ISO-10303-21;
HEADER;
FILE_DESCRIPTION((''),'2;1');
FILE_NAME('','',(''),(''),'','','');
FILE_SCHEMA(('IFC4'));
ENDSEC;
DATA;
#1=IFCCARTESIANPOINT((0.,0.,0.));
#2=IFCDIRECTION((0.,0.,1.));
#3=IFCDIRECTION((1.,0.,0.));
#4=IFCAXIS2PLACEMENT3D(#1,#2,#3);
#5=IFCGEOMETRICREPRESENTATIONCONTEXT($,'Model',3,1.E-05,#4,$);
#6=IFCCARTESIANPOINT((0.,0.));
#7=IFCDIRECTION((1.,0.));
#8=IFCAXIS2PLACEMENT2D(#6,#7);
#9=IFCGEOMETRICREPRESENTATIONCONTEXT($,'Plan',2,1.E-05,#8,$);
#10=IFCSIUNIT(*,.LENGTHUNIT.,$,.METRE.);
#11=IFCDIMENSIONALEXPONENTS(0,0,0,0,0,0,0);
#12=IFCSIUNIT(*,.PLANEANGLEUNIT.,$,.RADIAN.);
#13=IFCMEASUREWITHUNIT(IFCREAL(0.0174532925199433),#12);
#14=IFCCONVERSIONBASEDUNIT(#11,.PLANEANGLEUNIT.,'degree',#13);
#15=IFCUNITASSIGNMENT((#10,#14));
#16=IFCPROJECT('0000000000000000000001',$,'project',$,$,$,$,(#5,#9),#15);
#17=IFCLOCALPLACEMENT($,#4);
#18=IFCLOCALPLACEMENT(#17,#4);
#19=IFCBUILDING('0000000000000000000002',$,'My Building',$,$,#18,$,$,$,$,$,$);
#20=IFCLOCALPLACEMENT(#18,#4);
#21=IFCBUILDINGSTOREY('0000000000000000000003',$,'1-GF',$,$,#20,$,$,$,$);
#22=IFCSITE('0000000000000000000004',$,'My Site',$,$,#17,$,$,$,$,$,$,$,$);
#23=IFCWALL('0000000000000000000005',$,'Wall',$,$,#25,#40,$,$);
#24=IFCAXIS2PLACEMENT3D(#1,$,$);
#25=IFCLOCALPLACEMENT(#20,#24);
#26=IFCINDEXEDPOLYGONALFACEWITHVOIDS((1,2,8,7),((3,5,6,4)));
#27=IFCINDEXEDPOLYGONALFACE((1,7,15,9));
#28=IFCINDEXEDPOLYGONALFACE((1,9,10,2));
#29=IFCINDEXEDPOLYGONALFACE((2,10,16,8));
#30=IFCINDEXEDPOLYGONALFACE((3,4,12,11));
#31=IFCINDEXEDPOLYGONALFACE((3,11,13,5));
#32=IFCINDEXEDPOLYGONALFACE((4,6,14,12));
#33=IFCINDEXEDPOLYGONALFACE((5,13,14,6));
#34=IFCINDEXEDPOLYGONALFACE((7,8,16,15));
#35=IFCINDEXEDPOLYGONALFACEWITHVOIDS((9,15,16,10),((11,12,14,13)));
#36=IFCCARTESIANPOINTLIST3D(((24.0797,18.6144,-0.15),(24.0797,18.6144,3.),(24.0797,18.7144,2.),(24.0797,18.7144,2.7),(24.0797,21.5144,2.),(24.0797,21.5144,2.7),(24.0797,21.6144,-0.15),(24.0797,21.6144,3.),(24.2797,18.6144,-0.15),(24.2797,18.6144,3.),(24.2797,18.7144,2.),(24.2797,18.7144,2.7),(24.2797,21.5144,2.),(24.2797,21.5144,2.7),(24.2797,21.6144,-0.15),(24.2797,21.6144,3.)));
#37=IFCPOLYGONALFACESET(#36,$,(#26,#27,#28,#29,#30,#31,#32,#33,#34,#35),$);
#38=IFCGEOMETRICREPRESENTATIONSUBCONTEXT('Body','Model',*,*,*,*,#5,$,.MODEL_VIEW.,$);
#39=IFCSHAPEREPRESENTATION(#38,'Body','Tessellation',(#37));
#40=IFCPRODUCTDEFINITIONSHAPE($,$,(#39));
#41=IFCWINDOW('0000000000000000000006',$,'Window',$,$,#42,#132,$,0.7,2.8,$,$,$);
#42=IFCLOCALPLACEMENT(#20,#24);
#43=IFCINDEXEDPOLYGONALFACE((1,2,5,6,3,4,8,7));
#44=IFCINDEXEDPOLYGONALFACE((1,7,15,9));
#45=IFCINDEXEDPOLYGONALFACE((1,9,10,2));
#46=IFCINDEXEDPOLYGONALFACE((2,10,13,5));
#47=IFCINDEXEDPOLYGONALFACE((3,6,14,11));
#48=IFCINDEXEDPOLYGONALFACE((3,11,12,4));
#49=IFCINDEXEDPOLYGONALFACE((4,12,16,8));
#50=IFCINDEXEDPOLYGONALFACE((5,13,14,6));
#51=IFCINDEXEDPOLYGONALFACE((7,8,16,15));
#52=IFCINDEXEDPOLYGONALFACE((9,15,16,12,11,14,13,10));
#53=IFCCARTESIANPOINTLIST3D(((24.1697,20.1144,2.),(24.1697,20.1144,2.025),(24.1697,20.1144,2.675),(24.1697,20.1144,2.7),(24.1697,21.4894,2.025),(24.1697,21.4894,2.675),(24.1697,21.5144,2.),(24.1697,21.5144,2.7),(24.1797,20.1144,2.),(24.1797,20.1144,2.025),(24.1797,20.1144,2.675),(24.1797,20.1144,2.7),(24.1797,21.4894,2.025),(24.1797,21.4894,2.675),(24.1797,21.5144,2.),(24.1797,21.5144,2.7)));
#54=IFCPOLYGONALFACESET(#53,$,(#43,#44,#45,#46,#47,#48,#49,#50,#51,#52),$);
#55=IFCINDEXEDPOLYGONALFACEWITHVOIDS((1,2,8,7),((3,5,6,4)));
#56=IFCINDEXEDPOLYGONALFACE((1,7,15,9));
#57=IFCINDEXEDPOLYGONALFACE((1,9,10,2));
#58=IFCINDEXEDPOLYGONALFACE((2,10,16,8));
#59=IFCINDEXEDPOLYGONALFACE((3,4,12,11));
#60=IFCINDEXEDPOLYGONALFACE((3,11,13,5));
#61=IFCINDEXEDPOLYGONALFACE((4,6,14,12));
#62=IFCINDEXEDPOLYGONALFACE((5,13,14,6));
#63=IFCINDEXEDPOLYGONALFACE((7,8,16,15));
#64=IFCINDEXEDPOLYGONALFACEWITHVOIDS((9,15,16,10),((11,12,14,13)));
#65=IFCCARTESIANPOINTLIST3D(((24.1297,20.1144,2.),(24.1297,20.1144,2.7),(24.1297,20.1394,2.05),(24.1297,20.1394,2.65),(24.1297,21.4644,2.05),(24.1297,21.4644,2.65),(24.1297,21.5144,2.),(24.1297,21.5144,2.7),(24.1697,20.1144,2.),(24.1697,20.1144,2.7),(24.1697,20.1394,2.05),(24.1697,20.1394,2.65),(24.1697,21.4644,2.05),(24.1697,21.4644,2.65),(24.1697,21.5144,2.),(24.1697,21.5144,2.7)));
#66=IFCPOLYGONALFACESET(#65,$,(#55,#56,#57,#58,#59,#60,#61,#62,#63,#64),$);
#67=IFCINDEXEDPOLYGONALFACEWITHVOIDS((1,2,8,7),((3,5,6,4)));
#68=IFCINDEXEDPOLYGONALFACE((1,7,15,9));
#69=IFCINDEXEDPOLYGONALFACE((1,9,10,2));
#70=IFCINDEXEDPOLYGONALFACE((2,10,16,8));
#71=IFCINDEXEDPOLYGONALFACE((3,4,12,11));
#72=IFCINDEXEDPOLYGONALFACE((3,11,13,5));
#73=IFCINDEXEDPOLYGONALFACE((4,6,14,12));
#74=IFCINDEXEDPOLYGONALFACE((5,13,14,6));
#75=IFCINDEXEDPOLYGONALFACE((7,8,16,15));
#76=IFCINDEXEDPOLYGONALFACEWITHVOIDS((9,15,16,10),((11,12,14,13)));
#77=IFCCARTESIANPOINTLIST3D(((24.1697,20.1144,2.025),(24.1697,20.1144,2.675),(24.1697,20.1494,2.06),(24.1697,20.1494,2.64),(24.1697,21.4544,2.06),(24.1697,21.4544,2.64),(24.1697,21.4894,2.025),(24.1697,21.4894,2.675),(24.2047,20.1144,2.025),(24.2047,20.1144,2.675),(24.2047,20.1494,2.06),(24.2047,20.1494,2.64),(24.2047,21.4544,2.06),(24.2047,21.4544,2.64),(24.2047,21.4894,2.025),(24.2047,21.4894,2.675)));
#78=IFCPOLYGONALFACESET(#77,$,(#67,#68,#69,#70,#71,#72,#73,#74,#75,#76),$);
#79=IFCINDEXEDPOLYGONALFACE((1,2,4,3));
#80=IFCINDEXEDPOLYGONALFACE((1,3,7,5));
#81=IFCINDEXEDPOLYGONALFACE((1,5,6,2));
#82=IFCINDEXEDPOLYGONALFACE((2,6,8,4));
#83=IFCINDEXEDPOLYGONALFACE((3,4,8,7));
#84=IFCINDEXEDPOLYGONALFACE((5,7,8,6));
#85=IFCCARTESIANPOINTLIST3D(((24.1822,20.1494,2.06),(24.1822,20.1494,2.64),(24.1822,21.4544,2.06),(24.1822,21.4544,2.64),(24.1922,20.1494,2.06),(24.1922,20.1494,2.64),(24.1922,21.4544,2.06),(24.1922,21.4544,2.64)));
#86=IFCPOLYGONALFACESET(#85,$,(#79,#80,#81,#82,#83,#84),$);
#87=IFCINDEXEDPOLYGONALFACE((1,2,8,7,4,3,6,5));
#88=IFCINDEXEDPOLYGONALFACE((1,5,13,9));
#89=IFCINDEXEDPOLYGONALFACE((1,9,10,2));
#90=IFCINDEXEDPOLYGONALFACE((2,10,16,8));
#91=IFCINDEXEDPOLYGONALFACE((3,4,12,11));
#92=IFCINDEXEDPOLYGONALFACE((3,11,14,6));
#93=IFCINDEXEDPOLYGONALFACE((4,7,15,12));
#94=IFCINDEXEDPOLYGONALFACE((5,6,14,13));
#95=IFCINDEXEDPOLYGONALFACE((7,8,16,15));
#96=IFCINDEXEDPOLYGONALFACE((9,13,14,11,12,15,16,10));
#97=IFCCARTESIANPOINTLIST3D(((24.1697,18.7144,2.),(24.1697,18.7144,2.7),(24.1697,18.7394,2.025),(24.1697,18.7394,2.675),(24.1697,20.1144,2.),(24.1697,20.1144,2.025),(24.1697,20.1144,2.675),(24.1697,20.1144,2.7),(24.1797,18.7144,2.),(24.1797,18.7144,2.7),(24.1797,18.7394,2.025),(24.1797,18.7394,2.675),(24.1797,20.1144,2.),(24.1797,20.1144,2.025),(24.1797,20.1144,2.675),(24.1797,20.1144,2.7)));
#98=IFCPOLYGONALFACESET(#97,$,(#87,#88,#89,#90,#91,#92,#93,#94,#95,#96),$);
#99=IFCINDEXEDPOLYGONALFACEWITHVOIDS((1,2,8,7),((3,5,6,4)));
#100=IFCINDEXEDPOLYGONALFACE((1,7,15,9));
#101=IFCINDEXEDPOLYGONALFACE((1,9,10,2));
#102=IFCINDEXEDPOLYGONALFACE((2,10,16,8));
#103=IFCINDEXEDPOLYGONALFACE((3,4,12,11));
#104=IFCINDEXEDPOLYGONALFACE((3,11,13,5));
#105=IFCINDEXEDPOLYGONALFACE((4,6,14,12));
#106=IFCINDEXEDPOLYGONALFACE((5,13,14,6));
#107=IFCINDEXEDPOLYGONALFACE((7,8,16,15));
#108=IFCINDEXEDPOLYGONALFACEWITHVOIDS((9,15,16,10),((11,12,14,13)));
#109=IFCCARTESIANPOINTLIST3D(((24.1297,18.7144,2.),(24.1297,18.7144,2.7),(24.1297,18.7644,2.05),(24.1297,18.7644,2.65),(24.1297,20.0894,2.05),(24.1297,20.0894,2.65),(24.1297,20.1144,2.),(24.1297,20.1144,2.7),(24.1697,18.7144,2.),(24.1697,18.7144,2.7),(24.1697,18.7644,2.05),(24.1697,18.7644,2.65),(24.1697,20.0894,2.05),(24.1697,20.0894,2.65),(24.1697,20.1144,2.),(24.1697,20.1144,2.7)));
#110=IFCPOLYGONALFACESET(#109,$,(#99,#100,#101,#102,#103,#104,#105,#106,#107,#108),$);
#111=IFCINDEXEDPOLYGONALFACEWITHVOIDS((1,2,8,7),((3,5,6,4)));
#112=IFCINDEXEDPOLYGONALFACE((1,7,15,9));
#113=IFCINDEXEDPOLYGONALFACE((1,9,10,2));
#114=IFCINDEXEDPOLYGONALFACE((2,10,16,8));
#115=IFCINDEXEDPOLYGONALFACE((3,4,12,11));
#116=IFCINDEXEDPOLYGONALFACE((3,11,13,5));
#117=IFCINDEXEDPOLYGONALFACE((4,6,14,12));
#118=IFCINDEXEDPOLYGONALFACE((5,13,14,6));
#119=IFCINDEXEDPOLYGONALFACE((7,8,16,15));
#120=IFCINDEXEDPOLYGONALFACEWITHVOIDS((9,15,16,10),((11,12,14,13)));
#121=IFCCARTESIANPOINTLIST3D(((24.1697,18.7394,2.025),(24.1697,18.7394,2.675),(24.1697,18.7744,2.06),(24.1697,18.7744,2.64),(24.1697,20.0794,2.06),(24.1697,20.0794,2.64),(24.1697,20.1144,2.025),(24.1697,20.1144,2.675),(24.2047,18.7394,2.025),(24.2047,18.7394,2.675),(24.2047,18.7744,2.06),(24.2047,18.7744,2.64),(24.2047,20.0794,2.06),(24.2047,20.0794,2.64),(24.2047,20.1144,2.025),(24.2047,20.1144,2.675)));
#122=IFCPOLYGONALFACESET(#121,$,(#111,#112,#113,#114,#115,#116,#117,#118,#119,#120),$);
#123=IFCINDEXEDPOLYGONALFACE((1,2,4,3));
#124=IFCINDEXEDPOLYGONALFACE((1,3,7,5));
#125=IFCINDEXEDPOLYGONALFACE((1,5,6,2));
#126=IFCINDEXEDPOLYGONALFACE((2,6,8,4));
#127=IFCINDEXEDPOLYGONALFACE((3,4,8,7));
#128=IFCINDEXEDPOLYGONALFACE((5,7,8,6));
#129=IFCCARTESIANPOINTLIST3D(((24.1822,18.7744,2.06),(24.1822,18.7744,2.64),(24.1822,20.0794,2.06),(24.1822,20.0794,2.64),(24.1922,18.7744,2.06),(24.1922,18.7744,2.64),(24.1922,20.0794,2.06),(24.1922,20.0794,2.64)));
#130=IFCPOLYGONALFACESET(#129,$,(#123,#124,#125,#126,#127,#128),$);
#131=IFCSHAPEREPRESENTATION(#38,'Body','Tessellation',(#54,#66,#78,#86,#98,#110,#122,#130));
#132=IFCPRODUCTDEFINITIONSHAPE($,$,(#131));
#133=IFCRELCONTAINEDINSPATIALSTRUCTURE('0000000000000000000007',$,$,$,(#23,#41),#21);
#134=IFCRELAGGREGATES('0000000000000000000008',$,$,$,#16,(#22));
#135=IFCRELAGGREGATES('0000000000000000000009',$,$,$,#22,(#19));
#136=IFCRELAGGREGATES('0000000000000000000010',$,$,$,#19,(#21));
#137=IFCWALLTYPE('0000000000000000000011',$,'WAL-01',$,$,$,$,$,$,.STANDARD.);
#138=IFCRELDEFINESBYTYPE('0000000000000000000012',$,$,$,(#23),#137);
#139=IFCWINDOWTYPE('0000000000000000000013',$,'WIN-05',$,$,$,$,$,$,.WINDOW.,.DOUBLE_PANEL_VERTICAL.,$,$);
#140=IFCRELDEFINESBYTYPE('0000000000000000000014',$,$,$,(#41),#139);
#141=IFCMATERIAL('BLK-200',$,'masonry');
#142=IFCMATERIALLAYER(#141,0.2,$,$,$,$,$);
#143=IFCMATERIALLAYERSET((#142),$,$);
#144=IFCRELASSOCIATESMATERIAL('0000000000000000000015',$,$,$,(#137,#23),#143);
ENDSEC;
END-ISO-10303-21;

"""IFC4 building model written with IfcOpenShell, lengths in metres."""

from ifc_helpers import new_model, entity, si_unit, converted_unit, frame, origin_with_axes, origin_2d_with_axis, place, context, subcontext, project, spatial, line, indexed_curve, outline, extrude, shape, source, transform, mapped, material, layer, layer_set, layer_usage, type_object, type_shapes, element, fill, save


model = new_model("IFC4")

# Units and contexts
model_context = context("Model", 3, precision=1e-05, world=origin_with_axes())
plan_context = context("Plan", 2, precision=1e-05, world=origin_2d_with_axis())
body_context_1 = subcontext(model_context, "Body", "Model", "MODEL_VIEW")
body_context_2 = subcontext(plan_context, "Body", "Plan", "PLAN_VIEW")
ifc_project = project(units=[si_unit("LENGTHUNIT", "METRE"), converted_unit("PLANEANGLEUNIT", "degree", entity("IfcReal", 0.0174532925199433), si_unit("PLANEANGLEUNIT", "RADIAN"), dimensions=[0, 0, 0, 0, 0, 0, 0])], contexts=[model_context, plan_context])

# Site, building, storey
site_placement = place(None, origin_with_axes())
site = spatial("IfcSite", under=ifc_project, at=site_placement, Name="My Site")
building_placement = place(site_placement, origin_with_axes())
building = spatial("IfcBuilding", under=site, at=building_placement, Name="My Building")
storey_placement = place(building_placement, origin_with_axes())
storey = spatial("IfcBuildingStorey", under=building, at=storey_placement, Name="1-GF")

# Wall, opening, window
ifc_material_1 = material(Name="BLK-200", Category="masonry")
ifc_layer_1 = layer(ifc_material_1, 0.2)
ifc_layer_set_1 = layer_set([ifc_layer_1])
ifc_layer_usage_1 = layer_usage(ifc_layer_set_1, "AXIS2", "POSITIVE", 0.0)
wall_type_1 = type_object("IfcWallType", Name="WAL-01", PredefinedType="STANDARD", material=ifc_layer_set_1)
wall_1_placement = place(storey_placement, frame((24.0797, 21.6144, -0.15), z_axis=(0.0, 0.0, 1.0), x_axis=(-0.000001, -1.0, 0.0)))
wall_1 = element("IfcWall", 1, at=wall_1_placement, inside=storey, type_object=wall_type_1, material=ifc_layer_usage_1, Name="Wall", context=body_context_1, shape_type="SweptSolid", body=[
    extrude(outline(indexed_curve([(0.0, 0.0), (0.0, 0.2), (3.0, 0.2), (3.0, 0.0), (0.0, 0.0)], self_intersect=False)), origin_with_axes(), (0.0, 0.0, 1.0), 3.15),
])
shared_shape_1 = source(origin_with_axes(), body_context_1, "Body", "SweptSolid", [
    extrude(outline(indexed_curve([(0.0, 0.0), (2.8, 0.0), (2.8, 0.7), (0.0, 0.7)], segments=[line(1, 2, 3, 4, 1)])), frame((0.0, -0.6, 0.0), z_axis=(0.0, -1.0, 0.0), x_axis=(1.0, 0.0, 0.0)), (0.0, 0.0, -1.0), 1.2),
])
opening_1_placement = place(wall_1_placement, frame((0.1, 0.0, 2.15), z_axis=(0.0, 0.0, 1.0), x_axis=(1.0, 0.0, 0.0)))
opening_1 = element("IfcOpeningElement", 2, at=opening_1_placement, cuts=wall_1, PredefinedType="OPENING", context=body_context_1, shape_type="MappedRepresentation", body=[
    mapped(shared_shape_1, transform((0.0, 0.0, 0.0), x_axis=(1.0, 0.0, 0.0), y_axis=(0.0, 1.0, 0.0), z_axis=(0.0, 0.0, 1.0), scale=1.0)),
])
window_type_1 = type_object("IfcWindowType", Name="WIN-05", PartitioningType="DOUBLE_PANEL_VERTICAL", PredefinedType="WINDOW")
shared_shape_2 = source(origin_with_axes(), body_context_1, "Body", "SweptSolid", [
    extrude(outline(indexed_curve([(1.4, 0.0), (0.0, 0.0), (0.0, 0.7), (1.4, 0.7), (1.4, 0.675), (0.025, 0.675), (0.025, 0.025), (1.4, 0.025)], segments=[line(1, 2, 3, 4, 5, 6, 7, 8, 1)])), frame((0.0, 0.09, 0.0), z_axis=(0.0, -1.0, 0.0), x_axis=(1.0, 0.0, 0.0)), (0.0, 0.0, -1.0), 0.01),
    extrude(outline(indexed_curve([(0.0, 0.0), (1.4, 0.0), (1.4, 0.7), (0.0, 0.7)], segments=[line(1, 2, 3, 4, 1)]), holes=[indexed_curve([(0.05, 0.05), (1.375, 0.05), (1.375, 0.65), (0.05, 0.65)], segments=[line(1, 2, 3, 4, 1)])]), frame((0.0, 0.05, 0.0), z_axis=(0.0, -1.0, 0.0), x_axis=(1.0, 0.0, 0.0)), (0.0, 0.0, -1.0), 0.04),
    extrude(outline(indexed_curve([(0.0, 0.0), (1.375, 0.0), (1.375, 0.65), (0.0, 0.65)], segments=[line(1, 2, 3, 4, 1)]), holes=[indexed_curve([(0.035, 0.035), (1.34, 0.035), (1.34, 0.615), (0.035, 0.615)], segments=[line(1, 2, 3, 4, 1)])]), frame((0.025, 0.09, 0.025), z_axis=(0.0, -1.0, 0.0), x_axis=(1.0, 0.0, 0.0)), (0.0, 0.0, -1.0), 0.035),
    extrude(outline(indexed_curve([(0.035, 0.035), (1.34, 0.035), (1.34, 0.615), (0.035, 0.615)], segments=[line(1, 2, 3, 4, 1)])), frame((0.025, 0.1025, 0.025), z_axis=(0.0, -1.0, 0.0), x_axis=(1.0, 0.0, 0.0)), (0.0, 0.0, -1.0), 0.01),
    extrude(outline(indexed_curve([(0.0, 0.7), (1.4, 0.7), (1.4, 0.0), (0.0, 0.0), (0.0, 0.025), (1.375, 0.025), (1.375, 0.675), (0.0, 0.675)], segments=[line(1, 2, 3, 4, 5, 6, 7, 8, 1)])), frame((1.4, 0.09, 0.0), z_axis=(0.0, -1.0, 0.0), x_axis=(1.0, 0.0, 0.0)), (0.0, 0.0, -1.0), 0.01),
    extrude(outline(indexed_curve([(0.0, 0.0), (1.4, 0.0), (1.4, 0.7), (0.0, 0.7)], segments=[line(1, 2, 3, 4, 1)]), holes=[indexed_curve([(0.025, 0.05), (1.35, 0.05), (1.35, 0.65), (0.025, 0.65)], segments=[line(1, 2, 3, 4, 1)])]), frame((1.4, 0.05, 0.0), z_axis=(0.0, -1.0, 0.0), x_axis=(1.0, 0.0, 0.0)), (0.0, 0.0, -1.0), 0.04),
    extrude(outline(indexed_curve([(0.0, 0.0), (1.375, 0.0), (1.375, 0.65), (0.0, 0.65)], segments=[line(1, 2, 3, 4, 1)]), holes=[indexed_curve([(0.035, 0.035), (1.34, 0.035), (1.34, 0.615), (0.035, 0.615)], segments=[line(1, 2, 3, 4, 1)])]), frame((1.4, 0.09, 0.025), z_axis=(0.0, -1.0, 0.0), x_axis=(1.0, 0.0, 0.0)), (0.0, 0.0, -1.0), 0.035),
    extrude(outline(indexed_curve([(0.035, 0.035), (1.34, 0.035), (1.34, 0.615), (0.035, 0.615)], segments=[line(1, 2, 3, 4, 1)])), frame((1.4, 0.1025, 0.025), z_axis=(0.0, -1.0, 0.0), x_axis=(1.0, 0.0, 0.0)), (0.0, 0.0, -1.0), 0.01),
])
shared_shape_3 = source(origin_with_axes(), body_context_2, "Body", "Curve2D", [
    entity("IfcIndexedPolyCurve", entity("IfcCartesianPointList2D", [[0.05, 0.05], [1.375, 0.05]])),
    entity("IfcIndexedPolyCurve", entity("IfcCartesianPointList2D", [[0.0, 0.1], [0.025, 0.1], [0.025, 0.09], [0.05, 0.09], [0.05, 0.05], [0.0, 0.05]]), [entity("IfcLineIndex", [1, 2, 3, 4, 5, 6, 1])]),
    entity("IfcIndexedPolyCurve", entity("IfcCartesianPointList2D", [[1.4, 0.1], [1.4, 0.1], [1.4, 0.09], [1.375, 0.09], [1.375, 0.05], [1.4, 0.05]])),
    entity("IfcIndexedPolyCurve", entity("IfcCartesianPointList2D", [[0.025, 0.09], [0.06, 0.09], [0.06, 0.125], [0.025, 0.125]]), [entity("IfcLineIndex", [1, 2, 3, 4, 1])]),
    entity("IfcIndexedPolyCurve", entity("IfcCartesianPointList2D", [[1.4, 0.09], [1.365, 0.09], [1.365, 0.125], [1.4, 0.125]]), [entity("IfcLineIndex", [1, 2, 3, 4, 1])]),
    entity("IfcIndexedPolyCurve", entity("IfcCartesianPointList2D", [[0.06, 0.09], [1.365, 0.09]])),
    entity("IfcIndexedPolyCurve", entity("IfcCartesianPointList2D", [[0.06, 0.125], [1.365, 0.125]])),
    entity("IfcIndexedPolyCurve", entity("IfcCartesianPointList2D", [[0.06, 0.1075], [1.365, 0.1075]])),
    entity("IfcIndexedPolyCurve", entity("IfcCartesianPointList2D", [[1.425, 0.05], [2.75, 0.05]])),
    entity("IfcIndexedPolyCurve", entity("IfcCartesianPointList2D", [[1.4, 0.1], [1.4, 0.1], [1.4, 0.09], [1.425, 0.09], [1.425, 0.05], [1.4, 0.05]])),
    entity("IfcIndexedPolyCurve", entity("IfcCartesianPointList2D", [[2.8, 0.1], [2.775, 0.1], [2.775, 0.09], [2.75, 0.09], [2.75, 0.05], [2.8, 0.05]]), [entity("IfcLineIndex", [1, 2, 3, 4, 5, 6, 1])]),
    entity("IfcIndexedPolyCurve", entity("IfcCartesianPointList2D", [[1.4, 0.09], [1.435, 0.09], [1.435, 0.125], [1.4, 0.125]]), [entity("IfcLineIndex", [1, 2, 3, 4, 1])]),
    entity("IfcIndexedPolyCurve", entity("IfcCartesianPointList2D", [[2.775, 0.09], [2.74, 0.09], [2.74, 0.125], [2.775, 0.125]]), [entity("IfcLineIndex", [1, 2, 3, 4, 1])]),
    entity("IfcIndexedPolyCurve", entity("IfcCartesianPointList2D", [[1.435, 0.09], [2.74, 0.09]])),
    entity("IfcIndexedPolyCurve", entity("IfcCartesianPointList2D", [[1.435, 0.125], [2.74, 0.125]])),
    entity("IfcIndexedPolyCurve", entity("IfcCartesianPointList2D", [[1.435, 0.1075], [2.74, 0.1075]])),
])
type_shapes(window_type_1, [shared_shape_2, shared_shape_3])
window_1_placement = place(opening_1_placement, frame((0.0, 0.0, 0.0), z_axis=(0.0, 0.0, 1.0), x_axis=(1.0, 0.0, 0.0)))
window_1 = element("IfcWindow", 3, at=window_1_placement, inside=storey, type_object=window_type_1, Name="Window", OverallHeight=0.7, OverallWidth=2.8, shapes=[
    shape(body_context_1, "Body", "MappedRepresentation", [mapped(shared_shape_2, transform((0.0, 0.0, 0.0), x_axis=(1.0, 0.0, 0.0), y_axis=(0.0, 1.0, 0.0), z_axis=(0.0, 0.0, 1.0), scale=1.0))]),
    shape(body_context_2, "Body", "MappedRepresentation", [mapped(shared_shape_3, transform((0.0, 0.0, 0.0), x_axis=(1.0, 0.0, 0.0), y_axis=(0.0, 1.0, 0.0), z_axis=(0.0, 0.0, 1.0), scale=1.0))]),
])
fill(opening_1, window_1)

save(model, "model.ifc")
